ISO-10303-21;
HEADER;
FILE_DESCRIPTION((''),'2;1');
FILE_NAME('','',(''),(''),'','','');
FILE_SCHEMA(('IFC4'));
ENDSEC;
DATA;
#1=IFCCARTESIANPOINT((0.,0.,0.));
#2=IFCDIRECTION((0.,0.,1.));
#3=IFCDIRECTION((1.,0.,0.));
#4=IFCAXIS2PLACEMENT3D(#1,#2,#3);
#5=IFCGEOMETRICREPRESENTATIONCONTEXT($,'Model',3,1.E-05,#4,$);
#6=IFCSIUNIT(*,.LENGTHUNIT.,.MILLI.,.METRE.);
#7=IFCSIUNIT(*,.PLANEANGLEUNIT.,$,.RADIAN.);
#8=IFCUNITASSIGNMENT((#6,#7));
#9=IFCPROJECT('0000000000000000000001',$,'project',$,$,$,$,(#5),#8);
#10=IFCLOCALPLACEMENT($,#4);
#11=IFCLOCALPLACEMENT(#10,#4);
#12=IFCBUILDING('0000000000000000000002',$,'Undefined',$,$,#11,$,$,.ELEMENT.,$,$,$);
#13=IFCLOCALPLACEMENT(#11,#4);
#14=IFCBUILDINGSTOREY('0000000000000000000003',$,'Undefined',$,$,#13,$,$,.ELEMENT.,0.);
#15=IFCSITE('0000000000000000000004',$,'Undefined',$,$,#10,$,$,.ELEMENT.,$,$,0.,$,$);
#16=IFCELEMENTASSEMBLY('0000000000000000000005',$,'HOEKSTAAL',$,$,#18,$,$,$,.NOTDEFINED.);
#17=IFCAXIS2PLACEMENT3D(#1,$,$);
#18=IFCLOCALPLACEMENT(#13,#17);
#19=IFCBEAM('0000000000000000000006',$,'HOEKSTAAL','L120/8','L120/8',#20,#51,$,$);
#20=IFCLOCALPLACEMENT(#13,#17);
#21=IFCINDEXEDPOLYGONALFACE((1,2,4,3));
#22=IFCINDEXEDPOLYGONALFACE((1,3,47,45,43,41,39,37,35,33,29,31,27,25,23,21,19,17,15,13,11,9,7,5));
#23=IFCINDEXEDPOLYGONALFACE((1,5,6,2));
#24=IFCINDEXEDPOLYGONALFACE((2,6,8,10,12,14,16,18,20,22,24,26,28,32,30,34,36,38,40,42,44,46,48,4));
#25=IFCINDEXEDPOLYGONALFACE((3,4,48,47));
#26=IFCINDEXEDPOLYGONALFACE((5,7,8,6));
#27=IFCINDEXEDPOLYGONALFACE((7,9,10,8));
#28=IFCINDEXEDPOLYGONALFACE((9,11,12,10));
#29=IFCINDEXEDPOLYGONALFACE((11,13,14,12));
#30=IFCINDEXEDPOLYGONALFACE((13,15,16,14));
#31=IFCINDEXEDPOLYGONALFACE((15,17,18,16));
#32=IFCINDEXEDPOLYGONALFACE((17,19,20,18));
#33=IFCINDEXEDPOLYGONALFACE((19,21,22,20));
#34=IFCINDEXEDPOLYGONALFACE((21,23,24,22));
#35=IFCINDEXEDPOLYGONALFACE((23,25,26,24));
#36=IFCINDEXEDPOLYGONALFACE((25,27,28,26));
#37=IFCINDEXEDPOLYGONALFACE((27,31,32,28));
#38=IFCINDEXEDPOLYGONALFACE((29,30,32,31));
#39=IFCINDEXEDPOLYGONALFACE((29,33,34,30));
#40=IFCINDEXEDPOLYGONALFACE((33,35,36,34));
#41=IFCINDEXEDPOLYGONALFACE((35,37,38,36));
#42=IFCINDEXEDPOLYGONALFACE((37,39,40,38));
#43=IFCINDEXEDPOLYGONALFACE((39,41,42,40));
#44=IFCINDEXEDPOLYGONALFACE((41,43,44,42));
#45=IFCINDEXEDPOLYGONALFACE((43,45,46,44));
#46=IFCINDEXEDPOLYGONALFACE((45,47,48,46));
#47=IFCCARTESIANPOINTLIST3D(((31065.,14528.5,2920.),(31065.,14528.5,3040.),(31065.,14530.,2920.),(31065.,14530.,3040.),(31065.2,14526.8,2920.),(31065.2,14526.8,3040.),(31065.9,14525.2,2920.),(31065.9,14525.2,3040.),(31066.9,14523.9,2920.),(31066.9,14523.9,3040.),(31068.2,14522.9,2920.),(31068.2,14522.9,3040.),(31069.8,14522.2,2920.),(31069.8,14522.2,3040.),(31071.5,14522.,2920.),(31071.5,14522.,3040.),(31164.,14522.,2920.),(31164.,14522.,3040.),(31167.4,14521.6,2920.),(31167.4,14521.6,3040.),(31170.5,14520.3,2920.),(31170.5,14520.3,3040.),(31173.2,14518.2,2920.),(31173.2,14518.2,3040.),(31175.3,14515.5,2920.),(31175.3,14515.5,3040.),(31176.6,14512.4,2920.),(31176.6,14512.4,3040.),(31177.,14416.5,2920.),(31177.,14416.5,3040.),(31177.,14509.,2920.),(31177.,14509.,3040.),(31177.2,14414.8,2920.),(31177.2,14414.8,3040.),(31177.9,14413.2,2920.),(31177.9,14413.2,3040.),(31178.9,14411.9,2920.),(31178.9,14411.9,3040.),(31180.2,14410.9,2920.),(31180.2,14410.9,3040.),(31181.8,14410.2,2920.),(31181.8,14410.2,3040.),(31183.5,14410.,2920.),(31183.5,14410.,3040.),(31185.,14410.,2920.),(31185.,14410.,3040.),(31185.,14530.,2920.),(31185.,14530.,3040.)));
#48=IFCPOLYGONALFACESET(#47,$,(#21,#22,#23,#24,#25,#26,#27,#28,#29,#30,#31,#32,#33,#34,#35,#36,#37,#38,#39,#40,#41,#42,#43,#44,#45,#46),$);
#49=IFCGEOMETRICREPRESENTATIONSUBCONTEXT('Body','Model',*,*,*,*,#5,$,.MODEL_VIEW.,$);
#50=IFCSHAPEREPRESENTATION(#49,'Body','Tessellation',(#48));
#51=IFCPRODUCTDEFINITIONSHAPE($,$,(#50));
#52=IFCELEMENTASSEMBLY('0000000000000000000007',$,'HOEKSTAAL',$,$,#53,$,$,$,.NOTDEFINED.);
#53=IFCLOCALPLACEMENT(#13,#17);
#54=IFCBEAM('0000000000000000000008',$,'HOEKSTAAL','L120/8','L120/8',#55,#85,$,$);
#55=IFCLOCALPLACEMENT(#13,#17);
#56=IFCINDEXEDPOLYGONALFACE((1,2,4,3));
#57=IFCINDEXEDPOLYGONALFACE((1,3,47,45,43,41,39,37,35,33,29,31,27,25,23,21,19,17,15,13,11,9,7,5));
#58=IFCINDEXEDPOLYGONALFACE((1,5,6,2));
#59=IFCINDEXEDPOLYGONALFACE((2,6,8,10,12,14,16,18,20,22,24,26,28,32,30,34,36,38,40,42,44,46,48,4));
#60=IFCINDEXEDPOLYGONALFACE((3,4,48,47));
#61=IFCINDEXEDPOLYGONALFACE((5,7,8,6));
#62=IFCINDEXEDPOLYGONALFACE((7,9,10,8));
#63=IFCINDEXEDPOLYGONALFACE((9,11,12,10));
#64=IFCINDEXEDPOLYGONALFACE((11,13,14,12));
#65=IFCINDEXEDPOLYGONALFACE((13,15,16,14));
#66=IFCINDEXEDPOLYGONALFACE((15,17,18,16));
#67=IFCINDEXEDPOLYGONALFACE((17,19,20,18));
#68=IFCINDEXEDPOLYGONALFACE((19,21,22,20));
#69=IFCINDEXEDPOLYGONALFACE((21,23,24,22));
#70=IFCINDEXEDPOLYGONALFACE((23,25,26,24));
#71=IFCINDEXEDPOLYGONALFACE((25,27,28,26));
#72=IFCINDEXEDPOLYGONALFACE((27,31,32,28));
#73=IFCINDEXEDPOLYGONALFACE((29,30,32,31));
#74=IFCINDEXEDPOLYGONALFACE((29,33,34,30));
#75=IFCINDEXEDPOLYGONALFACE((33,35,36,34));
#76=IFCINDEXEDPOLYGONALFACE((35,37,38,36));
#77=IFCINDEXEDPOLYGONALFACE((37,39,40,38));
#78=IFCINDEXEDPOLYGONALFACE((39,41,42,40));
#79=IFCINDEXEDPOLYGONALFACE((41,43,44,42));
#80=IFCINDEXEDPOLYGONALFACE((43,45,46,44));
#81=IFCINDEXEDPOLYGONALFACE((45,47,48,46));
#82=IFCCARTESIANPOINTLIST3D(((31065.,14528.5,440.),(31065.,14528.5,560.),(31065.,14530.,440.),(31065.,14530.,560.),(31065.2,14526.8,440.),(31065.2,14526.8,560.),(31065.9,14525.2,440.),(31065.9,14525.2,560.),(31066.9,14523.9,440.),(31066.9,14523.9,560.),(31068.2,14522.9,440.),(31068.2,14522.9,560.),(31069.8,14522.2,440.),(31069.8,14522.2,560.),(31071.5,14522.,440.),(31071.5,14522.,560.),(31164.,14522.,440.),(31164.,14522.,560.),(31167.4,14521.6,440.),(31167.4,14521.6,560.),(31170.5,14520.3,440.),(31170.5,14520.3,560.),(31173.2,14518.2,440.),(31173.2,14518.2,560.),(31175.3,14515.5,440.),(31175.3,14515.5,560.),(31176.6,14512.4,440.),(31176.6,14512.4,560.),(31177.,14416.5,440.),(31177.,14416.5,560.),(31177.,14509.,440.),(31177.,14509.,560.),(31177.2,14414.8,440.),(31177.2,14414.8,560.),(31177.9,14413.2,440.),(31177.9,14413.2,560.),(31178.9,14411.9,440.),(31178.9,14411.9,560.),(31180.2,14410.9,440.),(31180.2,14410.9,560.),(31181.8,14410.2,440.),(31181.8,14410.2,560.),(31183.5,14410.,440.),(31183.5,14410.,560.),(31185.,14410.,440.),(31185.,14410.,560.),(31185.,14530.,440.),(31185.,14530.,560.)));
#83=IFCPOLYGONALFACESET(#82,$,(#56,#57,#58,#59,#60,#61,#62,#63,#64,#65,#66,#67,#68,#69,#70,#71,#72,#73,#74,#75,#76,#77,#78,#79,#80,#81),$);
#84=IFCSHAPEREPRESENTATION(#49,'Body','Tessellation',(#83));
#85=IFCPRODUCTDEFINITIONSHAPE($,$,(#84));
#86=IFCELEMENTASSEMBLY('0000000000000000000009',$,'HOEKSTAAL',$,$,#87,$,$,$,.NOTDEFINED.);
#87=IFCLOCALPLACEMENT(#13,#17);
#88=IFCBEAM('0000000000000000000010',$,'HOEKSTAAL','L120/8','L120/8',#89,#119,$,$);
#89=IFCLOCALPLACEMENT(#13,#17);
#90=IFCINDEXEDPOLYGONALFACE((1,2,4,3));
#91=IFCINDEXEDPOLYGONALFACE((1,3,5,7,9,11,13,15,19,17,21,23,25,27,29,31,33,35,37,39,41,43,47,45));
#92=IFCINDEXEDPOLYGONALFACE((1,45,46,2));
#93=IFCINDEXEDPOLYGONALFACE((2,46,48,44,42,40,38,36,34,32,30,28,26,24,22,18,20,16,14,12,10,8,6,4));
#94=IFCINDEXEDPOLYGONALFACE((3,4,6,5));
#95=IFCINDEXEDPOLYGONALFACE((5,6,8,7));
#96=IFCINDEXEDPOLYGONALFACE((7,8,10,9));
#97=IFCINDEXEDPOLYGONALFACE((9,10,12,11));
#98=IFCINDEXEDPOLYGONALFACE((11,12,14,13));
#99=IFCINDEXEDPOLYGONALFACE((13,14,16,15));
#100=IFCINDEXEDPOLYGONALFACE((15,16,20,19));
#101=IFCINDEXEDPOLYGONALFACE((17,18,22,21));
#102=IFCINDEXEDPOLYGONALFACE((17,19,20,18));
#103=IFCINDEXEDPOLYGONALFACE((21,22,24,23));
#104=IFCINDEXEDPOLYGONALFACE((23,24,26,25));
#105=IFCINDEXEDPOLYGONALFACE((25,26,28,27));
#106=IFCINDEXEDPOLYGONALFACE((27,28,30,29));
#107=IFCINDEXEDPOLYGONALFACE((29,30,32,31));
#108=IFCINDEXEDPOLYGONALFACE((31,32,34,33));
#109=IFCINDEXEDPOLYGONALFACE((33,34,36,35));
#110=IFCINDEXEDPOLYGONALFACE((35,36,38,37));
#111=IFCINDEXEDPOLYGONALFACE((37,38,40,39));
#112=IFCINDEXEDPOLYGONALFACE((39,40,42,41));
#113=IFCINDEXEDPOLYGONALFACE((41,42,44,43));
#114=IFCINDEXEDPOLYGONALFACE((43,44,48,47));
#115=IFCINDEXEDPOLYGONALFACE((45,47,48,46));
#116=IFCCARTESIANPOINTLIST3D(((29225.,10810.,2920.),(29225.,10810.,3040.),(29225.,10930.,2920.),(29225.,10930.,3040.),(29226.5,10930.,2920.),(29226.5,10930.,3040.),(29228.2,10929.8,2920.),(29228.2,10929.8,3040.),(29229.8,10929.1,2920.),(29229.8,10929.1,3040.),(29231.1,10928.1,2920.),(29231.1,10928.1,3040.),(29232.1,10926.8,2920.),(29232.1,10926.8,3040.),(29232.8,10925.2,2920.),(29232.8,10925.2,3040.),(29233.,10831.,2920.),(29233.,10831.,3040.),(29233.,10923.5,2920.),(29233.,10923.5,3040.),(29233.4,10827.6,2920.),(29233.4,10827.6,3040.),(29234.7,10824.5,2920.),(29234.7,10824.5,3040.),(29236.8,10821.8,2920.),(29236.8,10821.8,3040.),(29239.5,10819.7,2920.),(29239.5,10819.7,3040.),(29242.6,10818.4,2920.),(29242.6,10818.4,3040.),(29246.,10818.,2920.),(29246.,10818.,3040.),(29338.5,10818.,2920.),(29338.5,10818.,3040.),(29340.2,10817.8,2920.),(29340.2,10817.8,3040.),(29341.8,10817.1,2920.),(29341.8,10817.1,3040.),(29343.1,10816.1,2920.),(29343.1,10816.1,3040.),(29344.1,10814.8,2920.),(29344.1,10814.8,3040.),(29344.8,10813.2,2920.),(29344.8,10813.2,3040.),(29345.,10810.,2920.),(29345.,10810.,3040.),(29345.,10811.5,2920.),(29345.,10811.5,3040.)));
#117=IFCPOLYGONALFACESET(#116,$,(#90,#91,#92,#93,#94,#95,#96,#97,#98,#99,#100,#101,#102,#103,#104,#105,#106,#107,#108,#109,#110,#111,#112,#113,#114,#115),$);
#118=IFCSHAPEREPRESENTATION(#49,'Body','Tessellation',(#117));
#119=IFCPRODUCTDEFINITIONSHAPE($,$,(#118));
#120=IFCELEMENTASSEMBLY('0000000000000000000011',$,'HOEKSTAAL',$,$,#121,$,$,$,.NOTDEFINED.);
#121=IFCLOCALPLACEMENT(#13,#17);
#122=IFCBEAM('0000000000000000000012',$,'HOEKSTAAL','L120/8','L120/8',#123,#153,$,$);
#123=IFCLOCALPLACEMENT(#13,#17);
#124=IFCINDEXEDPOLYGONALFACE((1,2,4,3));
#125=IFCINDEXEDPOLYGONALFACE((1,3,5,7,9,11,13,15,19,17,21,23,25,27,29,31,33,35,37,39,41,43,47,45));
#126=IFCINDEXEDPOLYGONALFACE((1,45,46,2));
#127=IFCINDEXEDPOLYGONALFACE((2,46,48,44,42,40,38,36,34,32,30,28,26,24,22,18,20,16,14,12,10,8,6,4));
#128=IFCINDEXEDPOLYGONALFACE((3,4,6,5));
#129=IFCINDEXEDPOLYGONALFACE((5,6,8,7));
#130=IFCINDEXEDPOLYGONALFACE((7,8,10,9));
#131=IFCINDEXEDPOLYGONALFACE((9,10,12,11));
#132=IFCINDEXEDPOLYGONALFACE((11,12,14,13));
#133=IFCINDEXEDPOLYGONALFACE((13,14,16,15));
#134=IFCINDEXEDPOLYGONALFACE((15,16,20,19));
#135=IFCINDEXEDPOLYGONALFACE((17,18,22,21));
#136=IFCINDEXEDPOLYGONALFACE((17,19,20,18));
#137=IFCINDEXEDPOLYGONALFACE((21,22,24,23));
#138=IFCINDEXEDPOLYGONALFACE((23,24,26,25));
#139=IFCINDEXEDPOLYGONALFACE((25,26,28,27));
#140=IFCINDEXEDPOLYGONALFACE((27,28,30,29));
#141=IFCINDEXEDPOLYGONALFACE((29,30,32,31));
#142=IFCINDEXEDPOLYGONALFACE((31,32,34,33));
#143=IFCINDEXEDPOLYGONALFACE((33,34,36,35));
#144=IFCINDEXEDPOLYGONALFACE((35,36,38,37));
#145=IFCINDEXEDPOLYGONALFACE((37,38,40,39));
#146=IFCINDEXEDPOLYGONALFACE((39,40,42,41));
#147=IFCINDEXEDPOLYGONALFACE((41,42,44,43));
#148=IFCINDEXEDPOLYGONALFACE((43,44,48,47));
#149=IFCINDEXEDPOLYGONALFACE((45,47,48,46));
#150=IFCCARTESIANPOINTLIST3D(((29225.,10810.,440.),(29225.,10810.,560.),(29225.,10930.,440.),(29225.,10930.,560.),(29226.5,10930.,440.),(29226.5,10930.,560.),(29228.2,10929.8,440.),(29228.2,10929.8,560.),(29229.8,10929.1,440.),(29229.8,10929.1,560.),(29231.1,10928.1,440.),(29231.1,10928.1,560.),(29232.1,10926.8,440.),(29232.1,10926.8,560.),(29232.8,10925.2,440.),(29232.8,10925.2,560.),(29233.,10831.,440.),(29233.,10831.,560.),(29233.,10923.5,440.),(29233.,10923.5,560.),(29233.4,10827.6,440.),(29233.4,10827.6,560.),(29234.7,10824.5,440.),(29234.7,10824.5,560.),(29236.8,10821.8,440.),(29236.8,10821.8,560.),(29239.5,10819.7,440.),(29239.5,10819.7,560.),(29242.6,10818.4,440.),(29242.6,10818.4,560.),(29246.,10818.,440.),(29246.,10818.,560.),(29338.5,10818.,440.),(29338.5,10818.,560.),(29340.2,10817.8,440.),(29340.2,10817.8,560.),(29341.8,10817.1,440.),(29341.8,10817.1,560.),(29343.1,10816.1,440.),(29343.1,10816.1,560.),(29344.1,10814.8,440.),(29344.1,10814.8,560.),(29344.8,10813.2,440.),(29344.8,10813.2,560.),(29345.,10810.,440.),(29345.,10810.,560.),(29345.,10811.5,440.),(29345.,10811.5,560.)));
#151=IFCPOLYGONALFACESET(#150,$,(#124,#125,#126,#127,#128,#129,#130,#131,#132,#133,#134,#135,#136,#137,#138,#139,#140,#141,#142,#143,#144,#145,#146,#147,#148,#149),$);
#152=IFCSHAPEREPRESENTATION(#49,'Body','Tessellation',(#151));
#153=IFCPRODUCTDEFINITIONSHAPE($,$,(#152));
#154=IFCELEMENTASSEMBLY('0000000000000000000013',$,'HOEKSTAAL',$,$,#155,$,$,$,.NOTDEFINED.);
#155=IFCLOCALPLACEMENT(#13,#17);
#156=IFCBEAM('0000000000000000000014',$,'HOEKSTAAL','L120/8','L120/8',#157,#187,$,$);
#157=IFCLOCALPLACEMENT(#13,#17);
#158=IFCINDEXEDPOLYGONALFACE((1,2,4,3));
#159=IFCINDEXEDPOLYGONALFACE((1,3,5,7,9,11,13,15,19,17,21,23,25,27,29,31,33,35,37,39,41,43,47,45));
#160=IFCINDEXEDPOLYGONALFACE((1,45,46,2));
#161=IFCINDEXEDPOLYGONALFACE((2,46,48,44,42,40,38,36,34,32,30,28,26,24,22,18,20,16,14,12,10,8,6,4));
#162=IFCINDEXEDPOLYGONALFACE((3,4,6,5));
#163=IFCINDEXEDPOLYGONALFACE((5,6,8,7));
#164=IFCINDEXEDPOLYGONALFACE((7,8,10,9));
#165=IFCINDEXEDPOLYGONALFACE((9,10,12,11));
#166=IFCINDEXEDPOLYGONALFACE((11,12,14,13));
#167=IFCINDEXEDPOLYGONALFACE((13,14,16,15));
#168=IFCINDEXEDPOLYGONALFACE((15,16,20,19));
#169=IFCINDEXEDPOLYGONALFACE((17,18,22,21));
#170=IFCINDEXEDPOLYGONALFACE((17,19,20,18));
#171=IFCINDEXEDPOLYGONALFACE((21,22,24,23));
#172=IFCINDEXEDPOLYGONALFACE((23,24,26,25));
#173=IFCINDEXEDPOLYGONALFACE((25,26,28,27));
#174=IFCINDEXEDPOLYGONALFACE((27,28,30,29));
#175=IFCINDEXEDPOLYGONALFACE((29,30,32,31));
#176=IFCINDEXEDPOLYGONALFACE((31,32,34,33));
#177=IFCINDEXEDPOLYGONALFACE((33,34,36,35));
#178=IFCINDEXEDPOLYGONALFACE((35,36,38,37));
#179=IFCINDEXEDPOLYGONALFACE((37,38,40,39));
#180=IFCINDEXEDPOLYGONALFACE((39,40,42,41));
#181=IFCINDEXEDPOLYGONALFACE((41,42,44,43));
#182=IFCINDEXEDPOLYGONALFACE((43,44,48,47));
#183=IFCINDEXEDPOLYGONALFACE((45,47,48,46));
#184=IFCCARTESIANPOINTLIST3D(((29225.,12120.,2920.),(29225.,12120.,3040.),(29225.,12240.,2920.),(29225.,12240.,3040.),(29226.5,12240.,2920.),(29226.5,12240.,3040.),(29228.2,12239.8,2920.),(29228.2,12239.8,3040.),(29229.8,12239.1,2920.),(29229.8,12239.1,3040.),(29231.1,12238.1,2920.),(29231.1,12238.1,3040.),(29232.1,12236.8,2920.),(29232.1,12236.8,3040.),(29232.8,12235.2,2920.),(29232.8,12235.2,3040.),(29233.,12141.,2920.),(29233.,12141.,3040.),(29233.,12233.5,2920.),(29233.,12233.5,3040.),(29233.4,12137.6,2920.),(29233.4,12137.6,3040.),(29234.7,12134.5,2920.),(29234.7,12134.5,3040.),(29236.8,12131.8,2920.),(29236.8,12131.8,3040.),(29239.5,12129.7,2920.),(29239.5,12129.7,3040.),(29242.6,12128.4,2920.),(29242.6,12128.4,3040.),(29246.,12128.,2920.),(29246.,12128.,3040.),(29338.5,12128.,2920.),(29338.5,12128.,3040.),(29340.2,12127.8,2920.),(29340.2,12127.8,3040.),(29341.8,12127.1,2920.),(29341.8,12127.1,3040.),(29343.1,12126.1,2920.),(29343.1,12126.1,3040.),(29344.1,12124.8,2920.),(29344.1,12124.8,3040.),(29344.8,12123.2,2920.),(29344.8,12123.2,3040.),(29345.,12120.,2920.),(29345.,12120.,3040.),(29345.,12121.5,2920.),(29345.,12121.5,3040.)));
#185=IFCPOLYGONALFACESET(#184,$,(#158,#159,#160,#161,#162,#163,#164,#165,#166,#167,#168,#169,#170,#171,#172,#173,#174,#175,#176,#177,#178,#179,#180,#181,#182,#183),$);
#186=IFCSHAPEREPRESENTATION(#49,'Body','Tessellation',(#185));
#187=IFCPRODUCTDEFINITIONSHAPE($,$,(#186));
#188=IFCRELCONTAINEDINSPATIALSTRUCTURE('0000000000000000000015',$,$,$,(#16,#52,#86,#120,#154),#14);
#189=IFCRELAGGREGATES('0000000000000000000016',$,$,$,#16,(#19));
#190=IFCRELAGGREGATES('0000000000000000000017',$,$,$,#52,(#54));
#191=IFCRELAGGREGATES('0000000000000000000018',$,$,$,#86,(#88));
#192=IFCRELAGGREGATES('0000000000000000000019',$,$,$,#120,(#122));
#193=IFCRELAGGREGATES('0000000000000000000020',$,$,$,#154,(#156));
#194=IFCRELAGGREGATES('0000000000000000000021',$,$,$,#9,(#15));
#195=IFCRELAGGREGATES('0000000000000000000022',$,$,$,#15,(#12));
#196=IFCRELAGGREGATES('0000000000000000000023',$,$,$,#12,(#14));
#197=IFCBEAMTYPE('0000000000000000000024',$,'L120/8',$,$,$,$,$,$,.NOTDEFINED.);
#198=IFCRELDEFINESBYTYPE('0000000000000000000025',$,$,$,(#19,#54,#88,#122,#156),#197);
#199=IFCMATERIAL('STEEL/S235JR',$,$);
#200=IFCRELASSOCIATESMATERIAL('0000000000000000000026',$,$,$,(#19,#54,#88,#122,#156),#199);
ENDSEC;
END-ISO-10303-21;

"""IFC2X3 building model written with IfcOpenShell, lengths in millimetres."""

from ifc_helpers import new_model, si_unit, frame, origin_with_axes, origin_2d_with_axis, place, context, subcontext, project, spatial, l_section, extrude, material, type_object, element, aggregate, save


model = new_model("IFC2X3")

# Units and contexts
model_context = context("Model", 3, precision=1e-05, world=origin_with_axes())
body_context = subcontext(model_context, "Body", "Model", "MODEL_VIEW")
ifc_project = project(units=[si_unit("LENGTHUNIT", "METRE", prefix="MILLI"), si_unit("PLANEANGLEUNIT", "RADIAN")], contexts=[model_context])

# Site, building, storey
site_placement = place(None, origin_with_axes())
site = spatial("IfcSite", under=ifc_project, at=site_placement, Name="Undefined", CompositionType="ELEMENT", RefElevation=0.0)
building_placement = place(site_placement, origin_with_axes())
building = spatial("IfcBuilding", under=site, at=building_placement, Name="Undefined", CompositionType="ELEMENT")
storey_placement = place(building_placement, origin_with_axes())
storey = spatial("IfcBuildingStorey", under=building, at=storey_placement, Name="Undefined", CompositionType="ELEMENT", Elevation=0.0)

# Element assemblies, beams
ifc_material_1 = material(Name="STEEL/S235JR")
beam_type_1 = type_object("IfcBeamType", Name="L120/8", PredefinedType="NOTDEFINED")
assembly_1_placement = place(storey_placement, origin_with_axes())
assembly_1 = element("IfcElementAssembly", 1, at=assembly_1_placement, inside=storey, Name="HOEKSTAAL", PredefinedType="NOTDEFINED")
beam_1_placement = place(assembly_1_placement, frame((31125.0, 14470.0, 2920.0), z_axis=(-1.0, 0.0, 0.0), x_axis=(0.0, 0.0, 1.0)))
beam_1 = element("IfcBeam", 2, at=beam_1_placement, type_object=beam_type_1, material=ifc_material_1, Name="HOEKSTAAL", Description="L120/8", ObjectType="L120/8", context=body_context, shape_type="SweptSolid", body=[
    extrude(l_section(Depth=120.0, Width=120.0, Thickness=8.0, FilletRadius=13.0, EdgeRadius=6.5, at=origin_2d_with_axis()), frame((120.0, 0.0, 0.0), z_axis=(-1.0, 0.0, 0.0), x_axis=(0.0, -1.0, 0.0)), (0.0, 0.0, 1.0), 120.0),
])
aggregate(assembly_1, [beam_1])
assembly_2_placement = place(storey_placement, origin_with_axes())
assembly_2 = element("IfcElementAssembly", 3, at=assembly_2_placement, inside=storey, Name="HOEKSTAAL", PredefinedType="NOTDEFINED")
beam_2_placement = place(assembly_2_placement, frame((31125.0, 14470.0, 440.0), z_axis=(-1.0, 0.0, 0.0), x_axis=(0.0, 0.0, 1.0)))
beam_2 = element("IfcBeam", 4, at=beam_2_placement, type_object=beam_type_1, material=ifc_material_1, Name="HOEKSTAAL", Description="L120/8", ObjectType="L120/8", context=body_context, shape_type="SweptSolid", body=[
    extrude(l_section(Depth=120.0, Width=120.0, Thickness=8.0, FilletRadius=13.0, EdgeRadius=6.5, at=origin_2d_with_axis()), frame((120.0, 0.0, 0.0), z_axis=(-1.0, 0.0, 0.0), x_axis=(0.0, -1.0, 0.0)), (0.0, 0.0, 1.0), 120.0),
])
aggregate(assembly_2, [beam_2])
assembly_3_placement = place(storey_placement, origin_with_axes())
assembly_3 = element("IfcElementAssembly", 5, at=assembly_3_placement, inside=storey, Name="HOEKSTAAL", PredefinedType="NOTDEFINED")
beam_3_placement = place(assembly_3_placement, frame((29285.0, 10870.0, 2920.0), z_axis=(1.0, 0.0, 0.0), x_axis=(0.0, 0.0, 1.0)))
beam_3 = element("IfcBeam", 6, at=beam_3_placement, type_object=beam_type_1, material=ifc_material_1, Name="HOEKSTAAL", Description="L120/8", ObjectType="L120/8", context=body_context, shape_type="SweptSolid", body=[
    extrude(l_section(Depth=120.0, Width=120.0, Thickness=8.0, FilletRadius=13.0, EdgeRadius=6.5, at=origin_2d_with_axis()), frame((120.0, 0.0, 0.0), z_axis=(-1.0, 0.0, 0.0), x_axis=(0.0, -1.0, 0.0)), (0.0, 0.0, 1.0), 120.0),
])
aggregate(assembly_3, [beam_3])
assembly_4_placement = place(storey_placement, origin_with_axes())
assembly_4 = element("IfcElementAssembly", 7, at=assembly_4_placement, inside=storey, Name="HOEKSTAAL", PredefinedType="NOTDEFINED")
beam_4_placement = place(assembly_4_placement, frame((29285.0, 10870.0, 440.0), z_axis=(1.0, 0.0, 0.0), x_axis=(0.0, 0.0, 1.0)))
beam_4 = element("IfcBeam", 8, at=beam_4_placement, type_object=beam_type_1, material=ifc_material_1, Name="HOEKSTAAL", Description="L120/8", ObjectType="L120/8", context=body_context, shape_type="SweptSolid", body=[
    extrude(l_section(Depth=120.0, Width=120.0, Thickness=8.0, FilletRadius=13.0, EdgeRadius=6.5, at=origin_2d_with_axis()), frame((120.0, 0.0, 0.0), z_axis=(-1.0, 0.0, 0.0), x_axis=(0.0, -1.0, 0.0)), (0.0, 0.0, 1.0), 120.0),
])
aggregate(assembly_4, [beam_4])
assembly_5_placement = place(storey_placement, origin_with_axes())
assembly_5 = element("IfcElementAssembly", 9, at=assembly_5_placement, inside=storey, Name="HOEKSTAAL", PredefinedType="NOTDEFINED")
beam_5_placement = place(assembly_5_placement, frame((29285.0, 12180.0, 2920.0), z_axis=(1.0, 0.0, 0.0), x_axis=(0.0, 0.0, 1.0)))
beam_5 = element("IfcBeam", 10, at=beam_5_placement, type_object=beam_type_1, material=ifc_material_1, Name="HOEKSTAAL", Description="L120/8", ObjectType="L120/8", context=body_context, shape_type="SweptSolid", body=[
    extrude(l_section(Depth=120.0, Width=120.0, Thickness=8.0, FilletRadius=13.0, EdgeRadius=6.5, at=origin_2d_with_axis()), frame((120.0, 0.0, 0.0), z_axis=(-1.0, 0.0, 0.0), x_axis=(0.0, -1.0, 0.0)), (0.0, 0.0, 1.0), 120.0),
])
aggregate(assembly_5, [beam_5])

save(model, "model.ifc")
